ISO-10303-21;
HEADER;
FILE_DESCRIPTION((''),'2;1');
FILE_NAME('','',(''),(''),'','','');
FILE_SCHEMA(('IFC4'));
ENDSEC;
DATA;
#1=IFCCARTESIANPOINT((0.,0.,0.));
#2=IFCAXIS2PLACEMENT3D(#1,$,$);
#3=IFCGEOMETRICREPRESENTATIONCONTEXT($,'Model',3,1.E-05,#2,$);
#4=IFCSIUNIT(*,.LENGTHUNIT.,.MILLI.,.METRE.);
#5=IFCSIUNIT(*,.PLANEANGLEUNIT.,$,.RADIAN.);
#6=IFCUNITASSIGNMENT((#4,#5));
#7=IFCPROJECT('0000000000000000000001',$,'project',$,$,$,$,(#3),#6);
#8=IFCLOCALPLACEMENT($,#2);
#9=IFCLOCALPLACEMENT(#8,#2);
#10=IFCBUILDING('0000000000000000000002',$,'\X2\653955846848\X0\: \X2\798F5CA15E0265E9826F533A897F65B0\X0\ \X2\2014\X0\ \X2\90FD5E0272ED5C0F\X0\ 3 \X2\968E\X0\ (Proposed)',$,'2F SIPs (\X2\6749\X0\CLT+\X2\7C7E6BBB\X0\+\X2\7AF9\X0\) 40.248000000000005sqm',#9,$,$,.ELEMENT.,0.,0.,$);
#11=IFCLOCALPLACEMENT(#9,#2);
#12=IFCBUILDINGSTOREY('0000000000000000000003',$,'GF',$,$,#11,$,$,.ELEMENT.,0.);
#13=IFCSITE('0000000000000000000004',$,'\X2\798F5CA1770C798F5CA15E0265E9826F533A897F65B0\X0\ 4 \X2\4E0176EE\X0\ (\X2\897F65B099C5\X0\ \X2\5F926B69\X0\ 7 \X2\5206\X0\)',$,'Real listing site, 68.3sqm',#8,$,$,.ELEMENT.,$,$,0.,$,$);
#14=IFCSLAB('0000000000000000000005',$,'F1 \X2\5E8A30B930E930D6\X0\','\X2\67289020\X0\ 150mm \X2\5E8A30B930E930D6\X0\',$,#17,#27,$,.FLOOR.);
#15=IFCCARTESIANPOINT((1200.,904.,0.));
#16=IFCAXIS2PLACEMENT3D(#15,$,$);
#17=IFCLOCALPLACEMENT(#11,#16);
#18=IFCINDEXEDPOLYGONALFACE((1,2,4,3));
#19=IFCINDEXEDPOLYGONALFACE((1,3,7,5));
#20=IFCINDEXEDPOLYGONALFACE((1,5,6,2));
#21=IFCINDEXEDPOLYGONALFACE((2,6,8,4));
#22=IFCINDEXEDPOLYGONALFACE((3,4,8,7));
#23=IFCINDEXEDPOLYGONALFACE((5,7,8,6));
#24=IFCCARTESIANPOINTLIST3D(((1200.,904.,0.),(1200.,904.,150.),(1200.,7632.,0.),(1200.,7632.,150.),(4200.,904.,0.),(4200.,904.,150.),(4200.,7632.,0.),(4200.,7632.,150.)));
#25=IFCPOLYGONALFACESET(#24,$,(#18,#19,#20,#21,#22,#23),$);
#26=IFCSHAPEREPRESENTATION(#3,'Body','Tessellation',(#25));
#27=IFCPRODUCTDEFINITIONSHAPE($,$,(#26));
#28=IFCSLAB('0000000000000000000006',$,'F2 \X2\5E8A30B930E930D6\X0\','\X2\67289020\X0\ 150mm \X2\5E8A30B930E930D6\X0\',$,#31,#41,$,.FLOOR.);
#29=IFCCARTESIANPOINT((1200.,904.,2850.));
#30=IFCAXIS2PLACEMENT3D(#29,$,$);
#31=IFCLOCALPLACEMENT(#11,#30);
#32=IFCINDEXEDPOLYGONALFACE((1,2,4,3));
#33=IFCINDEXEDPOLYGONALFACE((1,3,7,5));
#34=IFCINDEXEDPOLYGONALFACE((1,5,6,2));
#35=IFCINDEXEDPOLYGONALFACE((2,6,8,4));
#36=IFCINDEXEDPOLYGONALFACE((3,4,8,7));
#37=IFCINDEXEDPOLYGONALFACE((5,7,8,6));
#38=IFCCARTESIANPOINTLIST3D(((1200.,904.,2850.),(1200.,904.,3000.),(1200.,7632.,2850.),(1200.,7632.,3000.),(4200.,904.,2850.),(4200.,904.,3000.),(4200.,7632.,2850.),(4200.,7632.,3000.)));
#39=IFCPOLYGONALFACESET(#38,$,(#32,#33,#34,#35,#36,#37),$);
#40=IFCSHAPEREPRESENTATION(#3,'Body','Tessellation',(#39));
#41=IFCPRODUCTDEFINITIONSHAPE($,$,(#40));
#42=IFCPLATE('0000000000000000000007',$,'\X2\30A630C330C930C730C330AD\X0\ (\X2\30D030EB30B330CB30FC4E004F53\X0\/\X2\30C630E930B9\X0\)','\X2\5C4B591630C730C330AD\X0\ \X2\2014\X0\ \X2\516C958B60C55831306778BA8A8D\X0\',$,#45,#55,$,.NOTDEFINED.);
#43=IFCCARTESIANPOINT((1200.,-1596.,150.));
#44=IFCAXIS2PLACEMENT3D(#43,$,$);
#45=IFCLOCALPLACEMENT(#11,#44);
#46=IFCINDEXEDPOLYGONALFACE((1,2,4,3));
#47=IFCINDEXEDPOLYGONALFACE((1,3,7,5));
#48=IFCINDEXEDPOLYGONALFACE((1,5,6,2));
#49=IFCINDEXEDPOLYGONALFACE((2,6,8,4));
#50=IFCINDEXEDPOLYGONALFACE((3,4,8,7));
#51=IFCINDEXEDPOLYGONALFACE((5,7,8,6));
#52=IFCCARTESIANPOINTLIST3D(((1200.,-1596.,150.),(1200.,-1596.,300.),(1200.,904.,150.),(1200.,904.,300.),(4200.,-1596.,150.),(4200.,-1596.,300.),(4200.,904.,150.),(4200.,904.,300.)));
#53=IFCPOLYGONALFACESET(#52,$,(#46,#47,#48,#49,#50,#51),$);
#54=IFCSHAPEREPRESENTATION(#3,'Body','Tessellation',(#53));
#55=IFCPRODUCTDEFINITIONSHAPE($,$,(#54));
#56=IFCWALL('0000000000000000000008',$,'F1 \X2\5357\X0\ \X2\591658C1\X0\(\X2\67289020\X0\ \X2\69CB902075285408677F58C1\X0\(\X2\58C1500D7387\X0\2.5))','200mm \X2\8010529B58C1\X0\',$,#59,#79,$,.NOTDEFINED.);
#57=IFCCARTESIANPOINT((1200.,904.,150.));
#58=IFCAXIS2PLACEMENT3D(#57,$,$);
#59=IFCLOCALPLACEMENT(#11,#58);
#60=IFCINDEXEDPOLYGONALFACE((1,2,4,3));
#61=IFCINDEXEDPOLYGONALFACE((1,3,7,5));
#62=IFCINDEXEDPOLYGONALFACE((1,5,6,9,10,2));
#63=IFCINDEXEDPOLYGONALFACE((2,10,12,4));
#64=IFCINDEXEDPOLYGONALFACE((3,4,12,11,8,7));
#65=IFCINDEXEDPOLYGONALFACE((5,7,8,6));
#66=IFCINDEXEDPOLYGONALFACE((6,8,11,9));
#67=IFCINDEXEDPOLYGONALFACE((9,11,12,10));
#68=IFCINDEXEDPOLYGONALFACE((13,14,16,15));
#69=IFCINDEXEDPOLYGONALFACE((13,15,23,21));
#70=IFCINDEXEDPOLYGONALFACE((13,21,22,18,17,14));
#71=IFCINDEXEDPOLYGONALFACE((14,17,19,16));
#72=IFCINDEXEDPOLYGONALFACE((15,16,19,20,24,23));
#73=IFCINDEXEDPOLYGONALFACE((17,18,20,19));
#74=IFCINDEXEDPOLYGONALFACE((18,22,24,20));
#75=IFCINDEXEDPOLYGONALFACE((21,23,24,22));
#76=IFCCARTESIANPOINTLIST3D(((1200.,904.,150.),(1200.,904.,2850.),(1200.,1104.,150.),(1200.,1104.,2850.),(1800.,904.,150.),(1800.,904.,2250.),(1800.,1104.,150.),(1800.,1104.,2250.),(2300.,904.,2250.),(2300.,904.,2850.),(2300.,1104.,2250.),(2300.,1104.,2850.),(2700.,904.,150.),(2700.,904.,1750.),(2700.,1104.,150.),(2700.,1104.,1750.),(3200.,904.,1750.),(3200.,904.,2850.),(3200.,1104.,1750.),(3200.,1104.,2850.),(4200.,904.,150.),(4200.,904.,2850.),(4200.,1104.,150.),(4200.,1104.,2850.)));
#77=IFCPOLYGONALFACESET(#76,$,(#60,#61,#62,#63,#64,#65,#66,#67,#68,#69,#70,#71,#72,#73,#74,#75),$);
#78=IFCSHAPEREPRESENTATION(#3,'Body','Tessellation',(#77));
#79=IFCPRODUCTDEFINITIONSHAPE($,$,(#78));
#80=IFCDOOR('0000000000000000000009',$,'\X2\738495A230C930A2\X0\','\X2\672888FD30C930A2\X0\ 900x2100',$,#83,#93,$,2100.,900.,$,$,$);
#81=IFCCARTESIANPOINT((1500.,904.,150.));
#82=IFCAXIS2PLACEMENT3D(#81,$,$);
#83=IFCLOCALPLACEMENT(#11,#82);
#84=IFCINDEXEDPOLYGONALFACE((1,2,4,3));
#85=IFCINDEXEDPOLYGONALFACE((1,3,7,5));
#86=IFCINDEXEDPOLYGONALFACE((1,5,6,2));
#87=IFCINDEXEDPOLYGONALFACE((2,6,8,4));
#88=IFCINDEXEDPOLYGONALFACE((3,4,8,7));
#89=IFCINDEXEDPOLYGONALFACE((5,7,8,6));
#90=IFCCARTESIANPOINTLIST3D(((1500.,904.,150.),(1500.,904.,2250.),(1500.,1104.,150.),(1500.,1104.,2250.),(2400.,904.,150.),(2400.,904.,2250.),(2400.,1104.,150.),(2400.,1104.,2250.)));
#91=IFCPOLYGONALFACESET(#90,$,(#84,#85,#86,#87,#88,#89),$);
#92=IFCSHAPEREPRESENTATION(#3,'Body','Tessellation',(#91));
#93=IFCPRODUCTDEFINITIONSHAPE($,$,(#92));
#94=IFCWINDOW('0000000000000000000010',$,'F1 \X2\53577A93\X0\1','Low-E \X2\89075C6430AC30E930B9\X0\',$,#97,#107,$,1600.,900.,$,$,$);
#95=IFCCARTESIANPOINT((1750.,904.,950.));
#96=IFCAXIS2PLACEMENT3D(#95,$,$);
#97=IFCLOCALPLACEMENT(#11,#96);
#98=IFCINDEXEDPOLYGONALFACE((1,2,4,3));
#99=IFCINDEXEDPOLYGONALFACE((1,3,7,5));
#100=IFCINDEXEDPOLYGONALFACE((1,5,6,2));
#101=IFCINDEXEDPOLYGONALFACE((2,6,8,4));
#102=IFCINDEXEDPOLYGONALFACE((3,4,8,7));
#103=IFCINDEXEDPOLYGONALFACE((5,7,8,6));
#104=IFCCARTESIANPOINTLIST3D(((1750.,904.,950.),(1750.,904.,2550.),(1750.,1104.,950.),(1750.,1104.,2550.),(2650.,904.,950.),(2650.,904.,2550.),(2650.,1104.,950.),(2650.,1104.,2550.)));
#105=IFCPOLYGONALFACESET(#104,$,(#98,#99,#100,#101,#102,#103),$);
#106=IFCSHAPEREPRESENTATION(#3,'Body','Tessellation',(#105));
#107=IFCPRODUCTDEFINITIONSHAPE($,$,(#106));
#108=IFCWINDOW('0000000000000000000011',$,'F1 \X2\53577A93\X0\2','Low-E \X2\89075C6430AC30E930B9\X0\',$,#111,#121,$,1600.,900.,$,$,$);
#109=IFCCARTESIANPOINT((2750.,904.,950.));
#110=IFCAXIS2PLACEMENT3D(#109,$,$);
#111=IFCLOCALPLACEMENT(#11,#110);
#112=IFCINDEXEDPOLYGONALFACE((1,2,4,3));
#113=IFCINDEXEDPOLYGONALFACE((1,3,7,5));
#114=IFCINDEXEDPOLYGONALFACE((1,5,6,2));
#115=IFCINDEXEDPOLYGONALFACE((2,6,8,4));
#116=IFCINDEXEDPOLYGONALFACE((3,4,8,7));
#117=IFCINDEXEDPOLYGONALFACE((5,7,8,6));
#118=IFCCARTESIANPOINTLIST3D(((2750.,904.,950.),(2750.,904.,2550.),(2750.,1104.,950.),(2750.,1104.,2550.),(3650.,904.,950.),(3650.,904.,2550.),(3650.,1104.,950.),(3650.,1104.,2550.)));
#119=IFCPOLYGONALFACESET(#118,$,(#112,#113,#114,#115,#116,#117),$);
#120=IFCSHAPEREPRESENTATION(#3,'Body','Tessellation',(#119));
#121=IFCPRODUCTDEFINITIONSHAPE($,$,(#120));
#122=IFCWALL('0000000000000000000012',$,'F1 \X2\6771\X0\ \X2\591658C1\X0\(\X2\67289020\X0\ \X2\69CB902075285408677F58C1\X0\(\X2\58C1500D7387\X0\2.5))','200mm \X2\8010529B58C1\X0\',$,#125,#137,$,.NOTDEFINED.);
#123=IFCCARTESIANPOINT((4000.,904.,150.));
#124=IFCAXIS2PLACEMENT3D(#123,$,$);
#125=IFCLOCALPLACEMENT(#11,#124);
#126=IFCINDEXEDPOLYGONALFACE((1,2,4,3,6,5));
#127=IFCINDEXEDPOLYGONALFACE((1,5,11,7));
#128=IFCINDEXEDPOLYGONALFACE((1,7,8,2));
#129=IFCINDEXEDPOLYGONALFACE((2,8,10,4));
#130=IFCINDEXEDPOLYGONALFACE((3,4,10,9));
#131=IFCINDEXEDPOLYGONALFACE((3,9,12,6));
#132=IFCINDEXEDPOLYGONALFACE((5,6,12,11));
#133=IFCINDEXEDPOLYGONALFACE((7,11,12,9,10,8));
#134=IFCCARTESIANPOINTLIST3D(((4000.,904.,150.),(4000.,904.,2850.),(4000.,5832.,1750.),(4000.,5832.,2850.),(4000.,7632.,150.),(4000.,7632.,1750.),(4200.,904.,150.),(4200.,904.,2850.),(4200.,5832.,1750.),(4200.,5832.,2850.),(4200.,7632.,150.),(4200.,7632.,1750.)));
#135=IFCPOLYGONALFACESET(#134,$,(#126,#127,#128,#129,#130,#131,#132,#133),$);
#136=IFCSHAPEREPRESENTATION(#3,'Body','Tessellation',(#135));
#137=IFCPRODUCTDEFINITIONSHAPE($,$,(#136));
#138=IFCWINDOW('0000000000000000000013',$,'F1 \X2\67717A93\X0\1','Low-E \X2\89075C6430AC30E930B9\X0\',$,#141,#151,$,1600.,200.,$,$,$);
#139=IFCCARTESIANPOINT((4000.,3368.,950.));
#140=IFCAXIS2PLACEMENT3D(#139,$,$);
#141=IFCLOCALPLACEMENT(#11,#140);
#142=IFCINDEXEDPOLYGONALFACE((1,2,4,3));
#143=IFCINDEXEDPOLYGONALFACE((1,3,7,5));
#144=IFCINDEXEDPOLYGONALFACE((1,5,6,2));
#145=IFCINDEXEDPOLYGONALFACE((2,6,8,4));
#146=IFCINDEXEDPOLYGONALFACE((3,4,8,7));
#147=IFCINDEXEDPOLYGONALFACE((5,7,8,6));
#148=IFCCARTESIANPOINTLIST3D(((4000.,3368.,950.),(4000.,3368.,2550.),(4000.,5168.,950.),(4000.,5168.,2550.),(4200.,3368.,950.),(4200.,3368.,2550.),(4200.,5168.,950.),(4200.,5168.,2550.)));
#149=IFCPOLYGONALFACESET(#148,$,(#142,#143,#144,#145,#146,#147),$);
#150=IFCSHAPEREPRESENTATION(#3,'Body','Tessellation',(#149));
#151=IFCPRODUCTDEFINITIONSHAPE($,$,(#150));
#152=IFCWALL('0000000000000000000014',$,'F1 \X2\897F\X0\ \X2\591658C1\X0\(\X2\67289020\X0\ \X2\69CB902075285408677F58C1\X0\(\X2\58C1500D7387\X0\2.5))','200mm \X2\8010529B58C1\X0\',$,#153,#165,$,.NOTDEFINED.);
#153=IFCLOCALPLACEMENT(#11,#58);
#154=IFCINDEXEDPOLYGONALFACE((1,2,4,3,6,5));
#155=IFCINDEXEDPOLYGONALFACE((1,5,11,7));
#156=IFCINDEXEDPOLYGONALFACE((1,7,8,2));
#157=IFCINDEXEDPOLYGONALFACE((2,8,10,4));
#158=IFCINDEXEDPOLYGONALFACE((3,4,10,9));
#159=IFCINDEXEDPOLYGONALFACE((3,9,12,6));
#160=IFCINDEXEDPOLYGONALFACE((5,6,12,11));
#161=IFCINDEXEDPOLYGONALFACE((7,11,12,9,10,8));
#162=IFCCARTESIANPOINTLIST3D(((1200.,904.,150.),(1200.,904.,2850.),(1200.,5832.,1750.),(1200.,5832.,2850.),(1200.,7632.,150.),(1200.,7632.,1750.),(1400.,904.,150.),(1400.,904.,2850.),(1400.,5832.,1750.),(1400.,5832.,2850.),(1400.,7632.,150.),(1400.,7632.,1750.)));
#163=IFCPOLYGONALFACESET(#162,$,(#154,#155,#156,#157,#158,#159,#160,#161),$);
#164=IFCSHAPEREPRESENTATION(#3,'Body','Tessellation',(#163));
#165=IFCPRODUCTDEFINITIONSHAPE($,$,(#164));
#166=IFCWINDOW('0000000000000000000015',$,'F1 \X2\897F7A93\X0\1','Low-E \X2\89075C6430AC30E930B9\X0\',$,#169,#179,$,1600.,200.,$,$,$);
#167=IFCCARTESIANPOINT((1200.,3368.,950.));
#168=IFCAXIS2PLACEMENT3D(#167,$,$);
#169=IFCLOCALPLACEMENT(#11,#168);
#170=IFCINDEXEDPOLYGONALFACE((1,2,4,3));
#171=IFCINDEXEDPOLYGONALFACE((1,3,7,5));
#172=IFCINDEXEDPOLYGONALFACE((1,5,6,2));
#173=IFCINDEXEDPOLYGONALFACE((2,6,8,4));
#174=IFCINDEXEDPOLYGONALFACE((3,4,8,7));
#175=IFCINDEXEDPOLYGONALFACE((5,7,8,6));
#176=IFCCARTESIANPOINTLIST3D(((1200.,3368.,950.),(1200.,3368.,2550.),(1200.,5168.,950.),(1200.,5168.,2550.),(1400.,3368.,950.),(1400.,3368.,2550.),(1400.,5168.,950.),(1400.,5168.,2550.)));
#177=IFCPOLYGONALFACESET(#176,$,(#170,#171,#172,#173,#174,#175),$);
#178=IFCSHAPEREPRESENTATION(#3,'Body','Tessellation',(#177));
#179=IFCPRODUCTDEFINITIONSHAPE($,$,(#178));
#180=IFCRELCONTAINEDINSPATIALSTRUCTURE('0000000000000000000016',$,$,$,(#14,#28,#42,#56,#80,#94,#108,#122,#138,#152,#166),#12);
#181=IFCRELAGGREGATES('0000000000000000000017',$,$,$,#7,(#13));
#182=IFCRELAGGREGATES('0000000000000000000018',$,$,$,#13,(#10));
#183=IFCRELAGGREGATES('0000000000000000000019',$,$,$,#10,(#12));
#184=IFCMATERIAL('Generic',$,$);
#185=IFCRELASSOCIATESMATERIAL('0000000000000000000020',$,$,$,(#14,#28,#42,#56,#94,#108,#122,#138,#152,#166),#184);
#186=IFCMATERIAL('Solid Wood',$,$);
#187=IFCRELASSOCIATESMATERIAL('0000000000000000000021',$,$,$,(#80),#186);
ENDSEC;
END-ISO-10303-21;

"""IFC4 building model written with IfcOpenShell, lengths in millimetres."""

from ifc_helpers import new_model, si_unit, frame, frame_2d, origin, place, context, project, spatial, rectangle, extrude, material, element, fill, save


model = new_model("IFC4")

# Units and contexts
model_context = context("Model", 3, precision=1e-05, world=origin())
ifc_project = project(units=[si_unit("LENGTHUNIT", "METRE", prefix="MILLI"), si_unit("PLANEANGLEUNIT", "RADIAN")], contexts=[model_context])

# Site, building, storey
site_placement = place(None, origin())
site = spatial("IfcSite", under=ifc_project, at=site_placement, Name="福岡県福岡市早良区西新 4 丁目 (西新駅 徒歩 7 分)", ObjectType="Real listing site, 68.3sqm", CompositionType="ELEMENT", RefElevation=0.0)
building_placement = place(site_placement, origin())
building = spatial("IfcBuilding", under=site, at=building_placement, Name="改善案: 福岡市早良区西新 — 都市狭小 3 階 (Proposed)", ObjectType="2F SIPs (杉CLT+籾殻+竹) 40.248000000000005sqm", CompositionType="ELEMENT", ElevationOfRefHeight=0.0, ElevationOfTerrain=0.0)
storey_placement = place(building_placement, origin())
storey = spatial("IfcBuildingStorey", under=building, at=storey_placement, Name="GF", CompositionType="ELEMENT", Elevation=0.0)

# Slabs
ifc_material_1 = material(Name="Generic")
slab_1_placement = place(storey_placement, frame((1200.0, 904.0, 0.0)))
element("IfcSlab", 1, at=slab_1_placement, inside=storey, material=ifc_material_1, Name="F1 床スラブ", Description="木造 150mm 床スラブ", PredefinedType="FLOOR", context=model_context, shape_type="SweptSolid", body=[
    extrude(rectangle(XDim=3000.0, YDim=6728.0, at=frame_2d((1500.0, 3364.0))), frame((1200.0, 904.0, 0.0)), (0.0, 0.0, 1.0), 150.0),
])
slab_2_placement = place(storey_placement, frame((1200.0, 904.0, 2850.0)))
element("IfcSlab", 2, at=slab_2_placement, inside=storey, material=ifc_material_1, Name="F2 床スラブ", Description="木造 150mm 床スラブ", PredefinedType="FLOOR", context=model_context, shape_type="SweptSolid", body=[
    extrude(rectangle(XDim=3000.0, YDim=6728.0, at=frame_2d((1500.0, 3364.0))), frame((1200.0, 904.0, 2850.0)), (0.0, 0.0, 1.0), 150.0),
])

# Plate
plate_placement = place(storey_placement, frame((1200.0, -1596.0, 150.0)))
element("IfcPlate", 3, at=plate_placement, inside=storey, material=ifc_material_1, Name="ウッドデッキ (バルコニー一体/テラス)", Description="屋外デッキ — 公開情報で確認", PredefinedType="NOTDEFINED", context=model_context, shape_type="SweptSolid", body=[
    extrude(rectangle(XDim=3000.0, YDim=2500.0, at=frame_2d((1500.0, 1250.0))), frame((1200.0, -1596.0, 150.0)), (0.0, 0.0, 1.0), 150.0),
])

# Wall, openings, door, windows
wall_1_placement = place(storey_placement, frame((1200.0, 904.0, 150.0)))
wall_1 = element("IfcWall", 4, at=wall_1_placement, inside=storey, material=ifc_material_1, Name="F1 南 外壁(木造 構造用合板壁(壁倍率2.5))", Description="200mm 耐力壁", PredefinedType="NOTDEFINED", context=model_context, shape_type="SweptSolid", body=[
    extrude(rectangle(XDim=3000.0, YDim=200.0, at=frame_2d((1500.0, 100.0))), frame((1200.0, 904.0, 150.0)), (0.0, 0.0, 1.0), 2700.0),
])
opening_1_placement = place(storey_placement, frame((1500.0, 904.0, 150.0)))
opening_1 = element("IfcOpeningElement", 5, at=opening_1_placement, cuts=wall_1, PredefinedType="NOTDEFINED", context=model_context, shape_type="SweptSolid", body=[
    extrude(rectangle(XDim=900.0, YDim=200.0, at=frame_2d((450.0, 100.0))), frame((1500.0, 904.0, 150.0)), (0.0, 0.0, 1.0), 2100.0),
])
opening_2_placement = place(storey_placement, frame((1750.0, 904.0, 950.0)))
opening_2 = element("IfcOpeningElement", 6, at=opening_2_placement, cuts=wall_1, PredefinedType="NOTDEFINED", context=model_context, shape_type="SweptSolid", body=[
    extrude(rectangle(XDim=900.0, YDim=200.0, at=frame_2d((450.0, 100.0))), frame((1750.0, 904.0, 950.0)), (0.0, 0.0, 1.0), 1600.0),
])
opening_3_placement = place(storey_placement, frame((2750.0, 904.0, 950.0)))
opening_3 = element("IfcOpeningElement", 7, at=opening_3_placement, cuts=wall_1, PredefinedType="NOTDEFINED", context=model_context, shape_type="SweptSolid", body=[
    extrude(rectangle(XDim=900.0, YDim=200.0, at=frame_2d((450.0, 100.0))), frame((2750.0, 904.0, 950.0)), (0.0, 0.0, 1.0), 1600.0),
])
ifc_material_2 = material(Name="Solid Wood")
door_placement = place(storey_placement, frame((1500.0, 904.0, 150.0)))
door = element("IfcDoor", 8, at=door_placement, inside=storey, material=ifc_material_2, Name="玄関ドア", Description="木製ドア 900x2100", OverallHeight=2100.0, OverallWidth=900.0, context=model_context, shape_type="SweptSolid", body=[
    extrude(rectangle(XDim=900.0, YDim=200.0, at=frame_2d((450.0, 100.0))), frame((1500.0, 904.0, 150.0)), (0.0, 0.0, 1.0), 2100.0),
])
fill(opening_1, door)
window_1_placement = place(storey_placement, frame((1750.0, 904.0, 950.0)))
window_1 = element("IfcWindow", 9, at=window_1_placement, inside=storey, material=ifc_material_1, Name="F1 南窓1", Description="Low-E 複層ガラス", OverallHeight=1600.0, OverallWidth=900.0, context=model_context, shape_type="SweptSolid", body=[
    extrude(rectangle(XDim=900.0, YDim=200.0, at=frame_2d((450.0, 100.0))), frame((1750.0, 904.0, 950.0)), (0.0, 0.0, 1.0), 1600.0),
])
fill(opening_2, window_1)
window_2_placement = place(storey_placement, frame((2750.0, 904.0, 950.0)))
window_2 = element("IfcWindow", 10, at=window_2_placement, inside=storey, material=ifc_material_1, Name="F1 南窓2", Description="Low-E 複層ガラス", OverallHeight=1600.0, OverallWidth=900.0, context=model_context, shape_type="SweptSolid", body=[
    extrude(rectangle(XDim=900.0, YDim=200.0, at=frame_2d((450.0, 100.0))), frame((2750.0, 904.0, 950.0)), (0.0, 0.0, 1.0), 1600.0),
])
fill(opening_3, window_2)

# Walls, openings, windows
wall_2_placement = place(storey_placement, frame((4000.0, 904.0, 150.0)))
wall_2 = element("IfcWall", 11, at=wall_2_placement, inside=storey, material=ifc_material_1, Name="F1 東 外壁(木造 構造用合板壁(壁倍率2.5))", Description="200mm 耐力壁", PredefinedType="NOTDEFINED", context=model_context, shape_type="SweptSolid", body=[
    extrude(rectangle(XDim=200.0, YDim=6728.0, at=frame_2d((100.0, 3364.0))), frame((4000.0, 904.0, 150.0)), (0.0, 0.0, 1.0), 2700.0),
])
opening_4_placement = place(storey_placement, frame((4000.0, 3368.0, 950.0)))
opening_4 = element("IfcOpeningElement", 12, at=opening_4_placement, cuts=wall_2, PredefinedType="NOTDEFINED", context=model_context, shape_type="SweptSolid", body=[
    extrude(rectangle(XDim=200.0, YDim=1800.0, at=frame_2d((100.0, 900.0))), frame((4000.0, 3368.0, 950.0)), (0.0, 0.0, 1.0), 1600.0),
])
window_3_placement = place(storey_placement, frame((4000.0, 3368.0, 950.0)))
window_3 = element("IfcWindow", 13, at=window_3_placement, inside=storey, material=ifc_material_1, Name="F1 東窓1", Description="Low-E 複層ガラス", OverallHeight=1600.0, OverallWidth=200.0, context=model_context, shape_type="SweptSolid", body=[
    extrude(rectangle(XDim=200.0, YDim=1800.0, at=frame_2d((100.0, 900.0))), frame((4000.0, 3368.0, 950.0)), (0.0, 0.0, 1.0), 1600.0),
])
fill(opening_4, window_3)
wall_3_placement = place(storey_placement, frame((1200.0, 904.0, 150.0)))
wall_3 = element("IfcWall", 14, at=wall_3_placement, inside=storey, material=ifc_material_1, Name="F1 西 外壁(木造 構造用合板壁(壁倍率2.5))", Description="200mm 耐力壁", PredefinedType="NOTDEFINED", context=model_context, shape_type="SweptSolid", body=[
    extrude(rectangle(XDim=200.0, YDim=6728.0, at=frame_2d((100.0, 3364.0))), frame((1200.0, 904.0, 150.0)), (0.0, 0.0, 1.0), 2700.0),
])
opening_5_placement = place(storey_placement, frame((1200.0, 3368.0, 950.0)))
opening_5 = element("IfcOpeningElement", 15, at=opening_5_placement, cuts=wall_3, PredefinedType="NOTDEFINED", context=model_context, shape_type="SweptSolid", body=[
    extrude(rectangle(XDim=200.0, YDim=1800.0, at=frame_2d((100.0, 900.0))), frame((1200.0, 3368.0, 950.0)), (0.0, 0.0, 1.0), 1600.0),
])
window_4_placement = place(storey_placement, frame((1200.0, 3368.0, 950.0)))
window_4 = element("IfcWindow", 16, at=window_4_placement, inside=storey, material=ifc_material_1, Name="F1 西窓1", Description="Low-E 複層ガラス", OverallHeight=1600.0, OverallWidth=200.0, context=model_context, shape_type="SweptSolid", body=[
    extrude(rectangle(XDim=200.0, YDim=1800.0, at=frame_2d((100.0, 900.0))), frame((1200.0, 3368.0, 950.0)), (0.0, 0.0, 1.0), 1600.0),
])
fill(opening_5, window_4)

save(model, "model.ifc")
